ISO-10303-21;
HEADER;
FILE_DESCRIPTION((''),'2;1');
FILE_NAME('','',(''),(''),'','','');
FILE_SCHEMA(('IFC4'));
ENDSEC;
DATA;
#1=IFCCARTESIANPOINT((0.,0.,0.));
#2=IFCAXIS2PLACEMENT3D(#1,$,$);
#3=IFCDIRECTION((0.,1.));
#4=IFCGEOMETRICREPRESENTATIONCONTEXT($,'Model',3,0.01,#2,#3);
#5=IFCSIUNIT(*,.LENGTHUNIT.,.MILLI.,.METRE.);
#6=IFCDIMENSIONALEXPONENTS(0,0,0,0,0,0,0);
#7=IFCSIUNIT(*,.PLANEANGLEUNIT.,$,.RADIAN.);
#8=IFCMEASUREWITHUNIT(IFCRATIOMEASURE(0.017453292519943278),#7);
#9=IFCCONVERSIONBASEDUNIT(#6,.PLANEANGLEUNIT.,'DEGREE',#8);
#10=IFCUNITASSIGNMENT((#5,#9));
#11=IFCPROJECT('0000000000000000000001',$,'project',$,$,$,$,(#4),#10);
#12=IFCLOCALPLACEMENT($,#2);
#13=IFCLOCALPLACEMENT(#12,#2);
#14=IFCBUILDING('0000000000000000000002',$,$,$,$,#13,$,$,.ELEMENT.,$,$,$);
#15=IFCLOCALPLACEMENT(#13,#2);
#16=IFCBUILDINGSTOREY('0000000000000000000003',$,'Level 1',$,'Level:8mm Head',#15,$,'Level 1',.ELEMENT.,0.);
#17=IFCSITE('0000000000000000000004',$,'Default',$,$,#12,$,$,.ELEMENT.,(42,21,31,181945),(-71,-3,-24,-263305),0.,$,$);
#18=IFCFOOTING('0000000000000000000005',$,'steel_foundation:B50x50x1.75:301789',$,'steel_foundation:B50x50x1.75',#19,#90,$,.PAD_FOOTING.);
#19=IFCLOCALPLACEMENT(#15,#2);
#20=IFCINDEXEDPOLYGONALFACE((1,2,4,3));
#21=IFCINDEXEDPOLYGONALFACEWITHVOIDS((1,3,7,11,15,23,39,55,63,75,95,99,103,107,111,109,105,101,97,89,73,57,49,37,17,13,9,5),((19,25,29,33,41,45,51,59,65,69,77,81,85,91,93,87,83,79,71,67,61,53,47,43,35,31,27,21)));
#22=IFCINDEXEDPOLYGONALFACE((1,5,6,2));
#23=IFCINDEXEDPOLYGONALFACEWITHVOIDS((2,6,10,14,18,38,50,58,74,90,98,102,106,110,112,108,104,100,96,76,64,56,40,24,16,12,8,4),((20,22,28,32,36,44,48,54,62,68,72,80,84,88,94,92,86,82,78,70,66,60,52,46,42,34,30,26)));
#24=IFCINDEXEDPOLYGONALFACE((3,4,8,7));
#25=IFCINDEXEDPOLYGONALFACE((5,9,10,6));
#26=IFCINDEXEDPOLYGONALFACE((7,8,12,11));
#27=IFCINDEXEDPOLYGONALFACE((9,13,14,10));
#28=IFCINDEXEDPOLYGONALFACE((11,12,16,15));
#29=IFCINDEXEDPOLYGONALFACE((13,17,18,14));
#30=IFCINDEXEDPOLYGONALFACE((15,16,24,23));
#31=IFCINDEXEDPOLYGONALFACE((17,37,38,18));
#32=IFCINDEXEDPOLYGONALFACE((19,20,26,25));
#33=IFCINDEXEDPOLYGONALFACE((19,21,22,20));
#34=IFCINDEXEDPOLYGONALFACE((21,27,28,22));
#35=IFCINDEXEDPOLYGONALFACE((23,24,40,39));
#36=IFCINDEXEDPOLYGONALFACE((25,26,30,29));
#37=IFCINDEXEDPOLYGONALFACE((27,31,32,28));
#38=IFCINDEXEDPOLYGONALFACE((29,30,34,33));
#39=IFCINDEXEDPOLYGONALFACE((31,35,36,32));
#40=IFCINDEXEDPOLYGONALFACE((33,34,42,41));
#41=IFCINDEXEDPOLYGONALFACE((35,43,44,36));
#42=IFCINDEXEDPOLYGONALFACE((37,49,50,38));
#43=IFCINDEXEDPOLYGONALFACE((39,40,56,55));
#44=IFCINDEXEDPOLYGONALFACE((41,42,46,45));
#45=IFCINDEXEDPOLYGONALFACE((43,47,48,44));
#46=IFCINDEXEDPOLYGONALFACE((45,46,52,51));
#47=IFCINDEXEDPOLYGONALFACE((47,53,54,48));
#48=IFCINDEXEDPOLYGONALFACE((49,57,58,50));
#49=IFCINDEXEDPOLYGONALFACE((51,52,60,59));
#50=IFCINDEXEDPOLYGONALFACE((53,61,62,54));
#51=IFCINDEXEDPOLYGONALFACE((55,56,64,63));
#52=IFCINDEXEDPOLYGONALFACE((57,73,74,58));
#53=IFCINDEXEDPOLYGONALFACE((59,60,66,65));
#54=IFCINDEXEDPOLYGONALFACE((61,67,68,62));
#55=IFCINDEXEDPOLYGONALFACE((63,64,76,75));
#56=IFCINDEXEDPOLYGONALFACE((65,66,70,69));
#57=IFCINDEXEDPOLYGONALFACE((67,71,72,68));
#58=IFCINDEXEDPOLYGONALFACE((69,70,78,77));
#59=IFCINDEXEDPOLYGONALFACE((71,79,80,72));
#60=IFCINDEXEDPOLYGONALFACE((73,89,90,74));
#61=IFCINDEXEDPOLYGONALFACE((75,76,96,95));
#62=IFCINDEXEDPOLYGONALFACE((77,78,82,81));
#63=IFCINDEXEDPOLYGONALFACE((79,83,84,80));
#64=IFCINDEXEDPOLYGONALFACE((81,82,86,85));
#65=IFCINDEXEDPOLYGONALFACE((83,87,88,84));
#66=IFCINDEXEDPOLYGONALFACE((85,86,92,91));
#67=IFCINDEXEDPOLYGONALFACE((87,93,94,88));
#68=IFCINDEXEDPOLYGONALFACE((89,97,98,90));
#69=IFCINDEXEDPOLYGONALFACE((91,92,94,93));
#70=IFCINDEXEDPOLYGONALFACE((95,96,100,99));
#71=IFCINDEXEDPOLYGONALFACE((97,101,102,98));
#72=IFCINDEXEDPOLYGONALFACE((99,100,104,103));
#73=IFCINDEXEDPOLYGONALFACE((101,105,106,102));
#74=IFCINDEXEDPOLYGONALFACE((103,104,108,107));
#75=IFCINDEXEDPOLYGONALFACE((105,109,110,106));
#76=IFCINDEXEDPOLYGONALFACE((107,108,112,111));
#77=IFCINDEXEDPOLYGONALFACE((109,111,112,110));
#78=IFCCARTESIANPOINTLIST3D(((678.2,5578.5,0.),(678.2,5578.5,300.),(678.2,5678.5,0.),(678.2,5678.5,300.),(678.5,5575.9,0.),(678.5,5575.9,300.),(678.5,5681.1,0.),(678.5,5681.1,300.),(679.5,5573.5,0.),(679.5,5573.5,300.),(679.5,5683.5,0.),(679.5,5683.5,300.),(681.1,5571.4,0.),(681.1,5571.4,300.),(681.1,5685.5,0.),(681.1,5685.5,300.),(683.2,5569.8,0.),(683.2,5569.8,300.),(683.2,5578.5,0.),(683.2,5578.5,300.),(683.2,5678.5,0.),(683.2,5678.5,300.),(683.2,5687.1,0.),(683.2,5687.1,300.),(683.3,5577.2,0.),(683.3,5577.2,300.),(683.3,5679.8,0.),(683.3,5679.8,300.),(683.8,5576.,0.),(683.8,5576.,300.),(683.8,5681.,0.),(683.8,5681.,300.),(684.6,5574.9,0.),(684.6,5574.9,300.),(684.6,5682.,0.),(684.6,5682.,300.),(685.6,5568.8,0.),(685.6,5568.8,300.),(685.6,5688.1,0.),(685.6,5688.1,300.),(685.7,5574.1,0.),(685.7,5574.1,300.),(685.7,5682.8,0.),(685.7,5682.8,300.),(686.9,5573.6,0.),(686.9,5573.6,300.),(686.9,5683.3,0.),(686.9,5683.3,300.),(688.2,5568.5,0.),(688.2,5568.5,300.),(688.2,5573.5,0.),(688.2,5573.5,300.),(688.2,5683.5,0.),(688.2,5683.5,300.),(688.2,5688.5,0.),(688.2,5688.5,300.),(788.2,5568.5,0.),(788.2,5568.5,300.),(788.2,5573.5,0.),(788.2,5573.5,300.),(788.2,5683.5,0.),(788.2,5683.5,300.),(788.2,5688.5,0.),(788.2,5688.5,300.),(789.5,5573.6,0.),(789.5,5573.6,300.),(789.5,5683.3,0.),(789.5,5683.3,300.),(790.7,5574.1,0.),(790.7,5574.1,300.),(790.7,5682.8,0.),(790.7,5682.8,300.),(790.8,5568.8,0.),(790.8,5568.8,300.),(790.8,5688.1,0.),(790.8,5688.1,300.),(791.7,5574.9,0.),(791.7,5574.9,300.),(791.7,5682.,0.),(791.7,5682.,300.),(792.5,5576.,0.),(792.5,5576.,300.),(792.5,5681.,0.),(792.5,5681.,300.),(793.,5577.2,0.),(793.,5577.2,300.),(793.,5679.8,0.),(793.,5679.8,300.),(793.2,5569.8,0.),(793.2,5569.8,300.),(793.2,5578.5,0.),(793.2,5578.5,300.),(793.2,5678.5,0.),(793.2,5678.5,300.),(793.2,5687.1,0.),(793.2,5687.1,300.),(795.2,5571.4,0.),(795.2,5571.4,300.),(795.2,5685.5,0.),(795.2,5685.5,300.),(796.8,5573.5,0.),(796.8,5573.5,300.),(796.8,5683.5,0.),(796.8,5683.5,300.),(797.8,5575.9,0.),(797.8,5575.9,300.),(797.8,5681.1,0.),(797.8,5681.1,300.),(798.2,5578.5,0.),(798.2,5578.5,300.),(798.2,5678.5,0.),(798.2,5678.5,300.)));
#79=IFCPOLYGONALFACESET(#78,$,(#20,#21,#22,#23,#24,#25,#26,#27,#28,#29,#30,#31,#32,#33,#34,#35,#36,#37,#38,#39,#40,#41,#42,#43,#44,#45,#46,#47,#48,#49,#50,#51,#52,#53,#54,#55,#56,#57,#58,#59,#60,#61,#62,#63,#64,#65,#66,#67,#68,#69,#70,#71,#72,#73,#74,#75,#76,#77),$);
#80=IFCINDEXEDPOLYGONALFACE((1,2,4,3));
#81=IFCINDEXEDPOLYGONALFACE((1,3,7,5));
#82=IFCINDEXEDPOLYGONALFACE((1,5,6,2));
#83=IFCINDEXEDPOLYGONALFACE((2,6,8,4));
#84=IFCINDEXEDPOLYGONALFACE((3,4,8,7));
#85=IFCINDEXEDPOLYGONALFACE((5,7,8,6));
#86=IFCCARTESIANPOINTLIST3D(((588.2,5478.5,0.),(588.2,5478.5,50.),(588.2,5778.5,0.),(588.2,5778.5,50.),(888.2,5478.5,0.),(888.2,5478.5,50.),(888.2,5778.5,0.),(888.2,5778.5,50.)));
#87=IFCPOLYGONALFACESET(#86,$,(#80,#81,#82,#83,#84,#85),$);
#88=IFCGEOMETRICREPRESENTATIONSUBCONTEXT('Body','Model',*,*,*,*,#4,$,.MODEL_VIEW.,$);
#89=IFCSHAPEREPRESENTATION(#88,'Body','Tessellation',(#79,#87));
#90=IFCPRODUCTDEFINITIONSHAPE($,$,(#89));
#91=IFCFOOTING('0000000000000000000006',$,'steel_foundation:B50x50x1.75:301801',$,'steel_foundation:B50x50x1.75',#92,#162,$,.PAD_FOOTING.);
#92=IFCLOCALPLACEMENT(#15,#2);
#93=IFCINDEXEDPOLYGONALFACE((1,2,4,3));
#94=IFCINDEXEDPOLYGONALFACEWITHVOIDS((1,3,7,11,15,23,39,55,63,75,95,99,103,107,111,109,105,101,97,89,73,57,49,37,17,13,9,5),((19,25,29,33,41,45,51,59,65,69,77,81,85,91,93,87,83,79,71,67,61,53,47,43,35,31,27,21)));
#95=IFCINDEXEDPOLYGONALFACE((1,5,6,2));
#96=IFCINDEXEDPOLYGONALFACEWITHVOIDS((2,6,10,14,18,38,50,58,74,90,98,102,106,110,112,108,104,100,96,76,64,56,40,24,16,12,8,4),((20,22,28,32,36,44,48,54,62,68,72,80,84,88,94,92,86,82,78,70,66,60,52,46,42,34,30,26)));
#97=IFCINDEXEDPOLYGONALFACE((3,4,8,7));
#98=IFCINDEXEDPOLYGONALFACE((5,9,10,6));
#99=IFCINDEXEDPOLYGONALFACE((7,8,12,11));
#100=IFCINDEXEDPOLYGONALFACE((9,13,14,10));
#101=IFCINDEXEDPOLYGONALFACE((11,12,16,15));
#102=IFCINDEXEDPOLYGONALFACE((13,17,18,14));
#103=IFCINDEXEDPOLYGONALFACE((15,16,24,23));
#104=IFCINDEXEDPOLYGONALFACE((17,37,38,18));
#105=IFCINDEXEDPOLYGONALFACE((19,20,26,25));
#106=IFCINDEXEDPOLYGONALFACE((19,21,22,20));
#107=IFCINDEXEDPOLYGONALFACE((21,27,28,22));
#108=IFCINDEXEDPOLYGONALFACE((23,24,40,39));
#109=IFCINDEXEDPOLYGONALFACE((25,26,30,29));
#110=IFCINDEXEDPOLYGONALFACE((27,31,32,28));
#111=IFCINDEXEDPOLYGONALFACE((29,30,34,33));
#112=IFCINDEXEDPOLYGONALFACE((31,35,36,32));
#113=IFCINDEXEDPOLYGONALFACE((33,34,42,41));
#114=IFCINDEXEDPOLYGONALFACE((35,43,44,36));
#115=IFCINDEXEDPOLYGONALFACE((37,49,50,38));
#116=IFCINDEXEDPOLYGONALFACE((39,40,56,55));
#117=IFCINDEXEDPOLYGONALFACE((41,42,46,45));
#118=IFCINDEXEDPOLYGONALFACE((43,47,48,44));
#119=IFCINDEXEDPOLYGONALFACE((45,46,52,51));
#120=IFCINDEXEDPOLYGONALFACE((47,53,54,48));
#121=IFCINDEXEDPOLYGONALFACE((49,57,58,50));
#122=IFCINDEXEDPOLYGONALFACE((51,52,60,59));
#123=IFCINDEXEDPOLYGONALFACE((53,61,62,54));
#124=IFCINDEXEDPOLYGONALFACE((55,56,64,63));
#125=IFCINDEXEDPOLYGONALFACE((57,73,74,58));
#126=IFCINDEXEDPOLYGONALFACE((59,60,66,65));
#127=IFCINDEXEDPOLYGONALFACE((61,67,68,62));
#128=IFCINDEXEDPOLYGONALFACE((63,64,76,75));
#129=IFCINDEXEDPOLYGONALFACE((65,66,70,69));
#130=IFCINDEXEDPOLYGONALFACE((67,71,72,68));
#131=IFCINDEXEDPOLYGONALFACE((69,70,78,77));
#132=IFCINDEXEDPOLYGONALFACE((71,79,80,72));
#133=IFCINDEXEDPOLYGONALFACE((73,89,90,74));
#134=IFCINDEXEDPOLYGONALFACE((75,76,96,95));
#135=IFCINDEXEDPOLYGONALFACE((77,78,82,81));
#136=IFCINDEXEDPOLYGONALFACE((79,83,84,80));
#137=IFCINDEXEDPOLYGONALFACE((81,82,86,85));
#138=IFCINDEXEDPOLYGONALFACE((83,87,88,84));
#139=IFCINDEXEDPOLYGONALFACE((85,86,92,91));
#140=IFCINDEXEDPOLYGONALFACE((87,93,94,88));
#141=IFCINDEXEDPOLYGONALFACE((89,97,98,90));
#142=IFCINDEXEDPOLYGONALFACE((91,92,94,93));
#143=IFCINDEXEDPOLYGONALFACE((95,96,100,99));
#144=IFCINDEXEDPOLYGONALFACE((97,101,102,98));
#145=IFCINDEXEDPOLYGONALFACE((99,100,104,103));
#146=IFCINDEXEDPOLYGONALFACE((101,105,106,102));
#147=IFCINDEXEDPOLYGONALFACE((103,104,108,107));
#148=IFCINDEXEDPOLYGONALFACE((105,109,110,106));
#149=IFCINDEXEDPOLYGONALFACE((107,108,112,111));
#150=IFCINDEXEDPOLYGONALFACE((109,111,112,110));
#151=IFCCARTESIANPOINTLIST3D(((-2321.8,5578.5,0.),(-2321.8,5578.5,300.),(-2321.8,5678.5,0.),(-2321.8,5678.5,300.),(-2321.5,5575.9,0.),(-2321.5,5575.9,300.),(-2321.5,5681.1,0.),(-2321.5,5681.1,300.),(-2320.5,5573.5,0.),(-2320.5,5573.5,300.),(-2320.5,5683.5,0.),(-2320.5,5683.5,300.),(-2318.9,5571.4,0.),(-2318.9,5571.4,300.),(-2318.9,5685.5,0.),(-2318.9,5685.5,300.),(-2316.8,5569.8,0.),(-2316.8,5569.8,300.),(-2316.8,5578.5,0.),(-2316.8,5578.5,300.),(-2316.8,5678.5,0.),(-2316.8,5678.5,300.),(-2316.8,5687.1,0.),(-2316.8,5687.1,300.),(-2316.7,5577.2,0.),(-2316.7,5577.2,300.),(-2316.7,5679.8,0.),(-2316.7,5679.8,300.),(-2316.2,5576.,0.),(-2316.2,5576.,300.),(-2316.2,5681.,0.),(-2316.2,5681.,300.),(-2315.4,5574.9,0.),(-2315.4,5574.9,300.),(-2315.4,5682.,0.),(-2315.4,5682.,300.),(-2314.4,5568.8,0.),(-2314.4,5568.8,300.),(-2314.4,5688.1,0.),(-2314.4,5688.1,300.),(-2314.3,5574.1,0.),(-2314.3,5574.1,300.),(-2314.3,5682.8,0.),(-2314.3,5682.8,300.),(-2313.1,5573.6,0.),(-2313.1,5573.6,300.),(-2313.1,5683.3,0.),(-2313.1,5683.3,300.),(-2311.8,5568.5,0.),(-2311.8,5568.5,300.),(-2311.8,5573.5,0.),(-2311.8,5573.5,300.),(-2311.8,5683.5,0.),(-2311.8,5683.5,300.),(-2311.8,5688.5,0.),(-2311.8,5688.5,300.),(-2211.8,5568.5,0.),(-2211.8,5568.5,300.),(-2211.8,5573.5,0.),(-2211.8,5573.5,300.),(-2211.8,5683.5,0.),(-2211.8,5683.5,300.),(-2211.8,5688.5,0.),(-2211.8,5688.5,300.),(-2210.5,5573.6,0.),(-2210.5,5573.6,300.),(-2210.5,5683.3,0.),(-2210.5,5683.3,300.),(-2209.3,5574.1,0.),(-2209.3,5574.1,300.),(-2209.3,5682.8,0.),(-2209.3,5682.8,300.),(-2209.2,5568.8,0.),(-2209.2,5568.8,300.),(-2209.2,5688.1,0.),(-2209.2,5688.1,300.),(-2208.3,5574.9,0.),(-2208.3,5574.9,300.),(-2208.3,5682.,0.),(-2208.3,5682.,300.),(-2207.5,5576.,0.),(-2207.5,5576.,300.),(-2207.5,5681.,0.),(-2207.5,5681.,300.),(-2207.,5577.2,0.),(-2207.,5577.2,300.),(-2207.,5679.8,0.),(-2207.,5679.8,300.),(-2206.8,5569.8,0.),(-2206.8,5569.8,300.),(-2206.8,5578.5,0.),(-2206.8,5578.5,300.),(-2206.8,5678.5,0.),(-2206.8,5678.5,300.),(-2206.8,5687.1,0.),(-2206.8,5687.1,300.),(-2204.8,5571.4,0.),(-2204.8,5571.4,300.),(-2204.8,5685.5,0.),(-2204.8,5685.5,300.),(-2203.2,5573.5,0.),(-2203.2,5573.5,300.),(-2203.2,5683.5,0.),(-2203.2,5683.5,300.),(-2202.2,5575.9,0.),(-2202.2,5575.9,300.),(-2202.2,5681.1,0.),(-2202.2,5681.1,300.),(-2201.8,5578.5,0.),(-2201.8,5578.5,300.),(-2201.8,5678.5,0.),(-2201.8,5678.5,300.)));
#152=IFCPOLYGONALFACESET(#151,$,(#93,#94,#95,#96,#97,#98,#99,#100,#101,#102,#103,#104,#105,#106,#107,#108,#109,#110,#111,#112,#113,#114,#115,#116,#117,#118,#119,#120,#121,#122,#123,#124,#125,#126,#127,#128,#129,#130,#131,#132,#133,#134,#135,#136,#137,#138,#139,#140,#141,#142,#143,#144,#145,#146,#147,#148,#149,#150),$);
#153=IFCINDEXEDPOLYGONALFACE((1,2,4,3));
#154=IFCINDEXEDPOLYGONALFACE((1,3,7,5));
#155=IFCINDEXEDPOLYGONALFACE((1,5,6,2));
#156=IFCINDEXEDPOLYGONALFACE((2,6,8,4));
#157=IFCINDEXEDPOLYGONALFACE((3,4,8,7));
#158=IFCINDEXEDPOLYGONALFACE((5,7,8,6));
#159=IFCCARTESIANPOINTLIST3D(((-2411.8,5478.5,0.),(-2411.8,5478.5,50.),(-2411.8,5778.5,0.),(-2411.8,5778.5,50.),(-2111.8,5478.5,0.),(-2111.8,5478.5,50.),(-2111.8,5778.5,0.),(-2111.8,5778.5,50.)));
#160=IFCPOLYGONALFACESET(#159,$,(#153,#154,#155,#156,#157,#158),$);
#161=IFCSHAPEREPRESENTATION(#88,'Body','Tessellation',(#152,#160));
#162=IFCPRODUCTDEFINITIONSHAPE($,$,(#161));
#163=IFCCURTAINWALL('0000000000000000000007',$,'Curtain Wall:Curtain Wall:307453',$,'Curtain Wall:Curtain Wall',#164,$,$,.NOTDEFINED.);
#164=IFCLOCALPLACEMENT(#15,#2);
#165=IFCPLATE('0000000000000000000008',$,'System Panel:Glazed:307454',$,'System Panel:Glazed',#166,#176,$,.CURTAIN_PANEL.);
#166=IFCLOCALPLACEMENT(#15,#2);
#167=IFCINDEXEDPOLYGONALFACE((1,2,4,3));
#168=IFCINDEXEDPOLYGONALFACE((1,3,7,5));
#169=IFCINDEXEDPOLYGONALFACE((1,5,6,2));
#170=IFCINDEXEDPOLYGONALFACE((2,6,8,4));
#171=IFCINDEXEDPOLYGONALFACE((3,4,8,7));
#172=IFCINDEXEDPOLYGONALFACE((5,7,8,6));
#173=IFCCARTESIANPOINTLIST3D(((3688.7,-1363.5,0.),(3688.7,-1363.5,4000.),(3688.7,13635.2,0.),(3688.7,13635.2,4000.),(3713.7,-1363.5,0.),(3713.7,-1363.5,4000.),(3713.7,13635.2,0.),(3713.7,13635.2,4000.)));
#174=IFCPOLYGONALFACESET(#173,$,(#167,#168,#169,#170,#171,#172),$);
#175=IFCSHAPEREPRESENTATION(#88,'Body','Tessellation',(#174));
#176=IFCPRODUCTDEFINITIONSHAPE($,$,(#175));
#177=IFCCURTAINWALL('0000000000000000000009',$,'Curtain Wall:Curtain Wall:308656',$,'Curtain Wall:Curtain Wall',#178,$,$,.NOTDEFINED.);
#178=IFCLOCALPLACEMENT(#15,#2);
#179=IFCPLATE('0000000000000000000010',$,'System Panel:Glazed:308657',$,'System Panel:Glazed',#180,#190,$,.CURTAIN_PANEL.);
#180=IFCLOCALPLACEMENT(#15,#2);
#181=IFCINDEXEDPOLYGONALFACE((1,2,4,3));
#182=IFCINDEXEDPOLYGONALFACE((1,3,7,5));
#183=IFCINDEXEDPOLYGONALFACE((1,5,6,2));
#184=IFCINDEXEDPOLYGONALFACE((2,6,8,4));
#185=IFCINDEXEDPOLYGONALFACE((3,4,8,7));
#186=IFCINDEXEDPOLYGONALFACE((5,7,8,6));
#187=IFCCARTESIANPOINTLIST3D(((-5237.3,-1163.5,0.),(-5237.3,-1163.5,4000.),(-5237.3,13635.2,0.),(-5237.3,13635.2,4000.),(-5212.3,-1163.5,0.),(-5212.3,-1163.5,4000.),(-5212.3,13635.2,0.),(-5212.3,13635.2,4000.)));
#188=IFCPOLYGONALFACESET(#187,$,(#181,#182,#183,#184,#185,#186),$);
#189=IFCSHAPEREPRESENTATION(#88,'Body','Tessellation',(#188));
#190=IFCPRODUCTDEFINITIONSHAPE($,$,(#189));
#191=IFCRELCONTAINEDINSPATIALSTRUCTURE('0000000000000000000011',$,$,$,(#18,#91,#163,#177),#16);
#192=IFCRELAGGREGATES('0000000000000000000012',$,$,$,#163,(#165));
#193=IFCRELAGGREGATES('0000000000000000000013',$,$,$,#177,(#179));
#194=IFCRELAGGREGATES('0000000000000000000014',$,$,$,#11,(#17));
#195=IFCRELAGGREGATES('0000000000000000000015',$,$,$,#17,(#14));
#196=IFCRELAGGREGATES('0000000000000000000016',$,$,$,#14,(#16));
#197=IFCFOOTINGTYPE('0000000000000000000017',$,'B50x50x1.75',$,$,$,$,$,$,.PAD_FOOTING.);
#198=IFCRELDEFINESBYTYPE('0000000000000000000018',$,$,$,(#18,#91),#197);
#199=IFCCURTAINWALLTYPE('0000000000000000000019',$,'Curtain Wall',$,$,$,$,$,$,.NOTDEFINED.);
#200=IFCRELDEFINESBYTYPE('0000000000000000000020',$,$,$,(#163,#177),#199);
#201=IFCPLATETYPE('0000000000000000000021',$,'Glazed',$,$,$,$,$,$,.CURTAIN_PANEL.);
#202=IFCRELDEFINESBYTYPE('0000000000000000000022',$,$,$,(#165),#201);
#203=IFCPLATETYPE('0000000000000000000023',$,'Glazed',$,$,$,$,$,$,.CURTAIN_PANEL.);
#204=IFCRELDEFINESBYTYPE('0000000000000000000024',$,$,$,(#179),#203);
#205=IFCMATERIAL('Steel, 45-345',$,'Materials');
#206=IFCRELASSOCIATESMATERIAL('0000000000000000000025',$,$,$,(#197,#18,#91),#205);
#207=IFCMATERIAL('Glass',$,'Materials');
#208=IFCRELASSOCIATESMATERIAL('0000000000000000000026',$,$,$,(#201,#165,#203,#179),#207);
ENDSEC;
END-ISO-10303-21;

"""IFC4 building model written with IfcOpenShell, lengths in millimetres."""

from ifc_helpers import new_model, entity, si_unit, converted_unit, direction, frame, origin, place, context, subcontext, project, spatial, line, arc, indexed_curve, outline, extrude, source, transform, mapped, material, type_object, type_shapes, element, aggregate, save


model = new_model("IFC4")

# Units and contexts
model_context = context("Model", 3, precision=0.01, world=origin(), true_north=direction((0.0, 1.0)))
body_context = subcontext(model_context, "Body", "Model", "MODEL_VIEW")
ifc_project = project(units=[si_unit("LENGTHUNIT", "METRE", prefix="MILLI"), converted_unit("PLANEANGLEUNIT", "DEGREE", entity("IfcRatioMeasure", 0.017453292519943278), si_unit("PLANEANGLEUNIT", "RADIAN"), dimensions=[0, 0, 0, 0, 0, 0, 0])], contexts=[model_context])

# Site, building, storey
site_placement = place(None, origin())
site = spatial("IfcSite", under=ifc_project, at=site_placement, Name="Default", CompositionType="ELEMENT", RefLatitude=(42, 21, 31, 181945), RefLongitude=(-71, -3, -24, -263305), RefElevation=0.0)
building_placement = place(site_placement, origin())
building = spatial("IfcBuilding", under=site, at=building_placement, CompositionType="ELEMENT")
storey_placement = place(building_placement, origin())
storey = spatial("IfcBuildingStorey", under=building, at=storey_placement, Name="Level 1", ObjectType="Level:8mm Head", LongName="Level 1", CompositionType="ELEMENT", Elevation=0.0)

# Footings
ifc_material_1 = material(Name="Steel, 45-345", Category="Materials")
footing_type = type_object("IfcFootingType", Name="B50x50x1.75", PredefinedType="PAD_FOOTING", material=ifc_material_1)
shared_shape_1 = source(origin(), body_context, "Body", "SweptSolid", [
    extrude(outline(indexed_curve([(-50.0, -60.0), (50.0, -60.0), (57.1, -57.1), (60.0, -50.0), (60.0, 50.0), (57.1, 57.1), (50.0, 60.0), (-50.0, 60.0), (-57.1, 57.1), (-60.0, 50.0), (-60.0, -50.0), (-57.1, -57.1)], segments=[line(1, 2), arc(2, 3, 4), line(4, 5), arc(5, 6, 7), line(7, 8), arc(8, 9, 10), line(10, 11), arc(11, 12, 1)], self_intersect=False), holes=[indexed_curve([(-50.0, -55.0), (-53.5, -53.5), (-55.0, -50.0), (-55.0, 50.0), (-53.5, 53.5), (-50.0, 55.0), (50.0, 55.0), (53.5, 53.5), (55.0, 50.0), (55.0, -50.0), (53.5, -53.5), (50.0, -55.0)], segments=[arc(1, 2, 3), line(3, 4), arc(4, 5, 6), line(6, 7), arc(7, 8, 9), line(9, 10), arc(10, 11, 12), line(12, 1)], self_intersect=False)]), frame((0.0, 0.0, 0.0), z_axis=(0.0, 0.0, 1.0), x_axis=(-1.0, 0.0, 0.0)), (0.0, 0.0, 1.0), 300.0),
    extrude(outline(indexed_curve([(-150.0, -150.0), (150.0, -150.0), (150.0, 150.0), (-150.0, 150.0), (-150.0, -150.0)], self_intersect=False)), frame((0.0, 0.0, 0.0), z_axis=(0.0, 0.0, 1.0), x_axis=(-1.0, 0.0, 0.0)), (0.0, 0.0, 1.0), 50.0),
])
type_shapes(footing_type, [shared_shape_1])
for number, where, name in (
    (1, (738.2, 5628.5, 0.0), "steel_foundation:B50x50x1.75:301789"),
    (2, (-2261.8, 5628.5, 0.0), "steel_foundation:B50x50x1.75:301801"),
):
    element("IfcFooting", number, at=place(storey_placement, frame(where)), inside=storey, type_object=footing_type, material=ifc_material_1, Name=name, ObjectType="steel_foundation:B50x50x1.75", PredefinedType="PAD_FOOTING", context=body_context, shape_type="MappedRepresentation", body=[
        mapped(shared_shape_1, transform((0.0, 0.0, 0.0), scale=1.0)),
    ])

# Curtain walls, plates
curtain_wall_type = type_object("IfcCurtainWallType", Name="Curtain Wall", PredefinedType="NOTDEFINED")
curtain_wall_1_placement = place(storey_placement, origin())
curtain_wall_1 = element("IfcCurtainWall", 3, at=curtain_wall_1_placement, inside=storey, type_object=curtain_wall_type, Name="Curtain Wall:Curtain Wall:307453", ObjectType="Curtain Wall:Curtain Wall", PredefinedType="NOTDEFINED")
ifc_material_2 = material(Name="Glass", Category="Materials")
plate_type_1 = type_object("IfcPlateType", Name="Glazed", PredefinedType="CURTAIN_PANEL", material=ifc_material_2)
shared_shape_2 = source(origin(), body_context, "Body", "SweptSolid", [
    extrude(outline(indexed_curve([(-12.5, -7499.3), (12.5, -7499.3), (12.5, 7499.3), (-12.5, 7499.3), (-12.5, -7499.3)], self_intersect=False)), frame((0.0, 37.0, 0.0), z_axis=(0.0, 0.0, 1.0), x_axis=(0.0, 1.0, 0.0)), (0.0, 0.0, 1.0), 4000.0),
])
type_shapes(plate_type_1, [shared_shape_2])
plate_1_placement = place(curtain_wall_1_placement, frame((3738.2, 6135.8, 0.0), z_axis=(0.0, 0.0, 1.0), x_axis=(0.0, 1.0, 0.0)))
plate_1 = element("IfcPlate", 4, at=plate_1_placement, type_object=plate_type_1, material=ifc_material_2, Name="System Panel:Glazed:307454", ObjectType="System Panel:Glazed", PredefinedType="CURTAIN_PANEL", context=body_context, shape_type="MappedRepresentation", body=[
    mapped(shared_shape_2, transform((0.0, 0.0, 0.0), scale=1.0)),
])
aggregate(curtain_wall_1, [plate_1])
curtain_wall_2_placement = place(storey_placement, origin())
curtain_wall_2 = element("IfcCurtainWall", 5, at=curtain_wall_2_placement, inside=storey, type_object=curtain_wall_type, Name="Curtain Wall:Curtain Wall:308656", ObjectType="Curtain Wall:Curtain Wall", PredefinedType="NOTDEFINED")
plate_type_2 = type_object("IfcPlateType", Name="Glazed", PredefinedType="CURTAIN_PANEL", material=ifc_material_2)
shared_shape_3 = source(origin(), body_context, "Body", "SweptSolid", [
    extrude(outline(indexed_curve([(-12.5, -7399.3), (12.5, -7399.3), (12.5, 7399.3), (-12.5, 7399.3), (-12.5, -7399.3)], self_intersect=False)), frame((0.0, 37.0, 0.0), z_axis=(0.0, 0.0, 1.0), x_axis=(0.0, 1.0, 0.0)), (0.0, 0.0, 1.0), 4000.0),
])
type_shapes(plate_type_2, [shared_shape_3])
plate_2_placement = place(curtain_wall_2_placement, frame((-5261.8, 6235.8, 0.0), z_axis=(0.0, 0.0, 1.0), x_axis=(0.0, -1.0, 0.0)))
plate_2 = element("IfcPlate", 6, at=plate_2_placement, type_object=plate_type_2, material=ifc_material_2, Name="System Panel:Glazed:308657", ObjectType="System Panel:Glazed", PredefinedType="CURTAIN_PANEL", context=body_context, shape_type="MappedRepresentation", body=[
    mapped(shared_shape_3, transform((0.0, 0.0, 0.0), scale=1.0)),
])
aggregate(curtain_wall_2, [plate_2])

save(model, "model.ifc")
